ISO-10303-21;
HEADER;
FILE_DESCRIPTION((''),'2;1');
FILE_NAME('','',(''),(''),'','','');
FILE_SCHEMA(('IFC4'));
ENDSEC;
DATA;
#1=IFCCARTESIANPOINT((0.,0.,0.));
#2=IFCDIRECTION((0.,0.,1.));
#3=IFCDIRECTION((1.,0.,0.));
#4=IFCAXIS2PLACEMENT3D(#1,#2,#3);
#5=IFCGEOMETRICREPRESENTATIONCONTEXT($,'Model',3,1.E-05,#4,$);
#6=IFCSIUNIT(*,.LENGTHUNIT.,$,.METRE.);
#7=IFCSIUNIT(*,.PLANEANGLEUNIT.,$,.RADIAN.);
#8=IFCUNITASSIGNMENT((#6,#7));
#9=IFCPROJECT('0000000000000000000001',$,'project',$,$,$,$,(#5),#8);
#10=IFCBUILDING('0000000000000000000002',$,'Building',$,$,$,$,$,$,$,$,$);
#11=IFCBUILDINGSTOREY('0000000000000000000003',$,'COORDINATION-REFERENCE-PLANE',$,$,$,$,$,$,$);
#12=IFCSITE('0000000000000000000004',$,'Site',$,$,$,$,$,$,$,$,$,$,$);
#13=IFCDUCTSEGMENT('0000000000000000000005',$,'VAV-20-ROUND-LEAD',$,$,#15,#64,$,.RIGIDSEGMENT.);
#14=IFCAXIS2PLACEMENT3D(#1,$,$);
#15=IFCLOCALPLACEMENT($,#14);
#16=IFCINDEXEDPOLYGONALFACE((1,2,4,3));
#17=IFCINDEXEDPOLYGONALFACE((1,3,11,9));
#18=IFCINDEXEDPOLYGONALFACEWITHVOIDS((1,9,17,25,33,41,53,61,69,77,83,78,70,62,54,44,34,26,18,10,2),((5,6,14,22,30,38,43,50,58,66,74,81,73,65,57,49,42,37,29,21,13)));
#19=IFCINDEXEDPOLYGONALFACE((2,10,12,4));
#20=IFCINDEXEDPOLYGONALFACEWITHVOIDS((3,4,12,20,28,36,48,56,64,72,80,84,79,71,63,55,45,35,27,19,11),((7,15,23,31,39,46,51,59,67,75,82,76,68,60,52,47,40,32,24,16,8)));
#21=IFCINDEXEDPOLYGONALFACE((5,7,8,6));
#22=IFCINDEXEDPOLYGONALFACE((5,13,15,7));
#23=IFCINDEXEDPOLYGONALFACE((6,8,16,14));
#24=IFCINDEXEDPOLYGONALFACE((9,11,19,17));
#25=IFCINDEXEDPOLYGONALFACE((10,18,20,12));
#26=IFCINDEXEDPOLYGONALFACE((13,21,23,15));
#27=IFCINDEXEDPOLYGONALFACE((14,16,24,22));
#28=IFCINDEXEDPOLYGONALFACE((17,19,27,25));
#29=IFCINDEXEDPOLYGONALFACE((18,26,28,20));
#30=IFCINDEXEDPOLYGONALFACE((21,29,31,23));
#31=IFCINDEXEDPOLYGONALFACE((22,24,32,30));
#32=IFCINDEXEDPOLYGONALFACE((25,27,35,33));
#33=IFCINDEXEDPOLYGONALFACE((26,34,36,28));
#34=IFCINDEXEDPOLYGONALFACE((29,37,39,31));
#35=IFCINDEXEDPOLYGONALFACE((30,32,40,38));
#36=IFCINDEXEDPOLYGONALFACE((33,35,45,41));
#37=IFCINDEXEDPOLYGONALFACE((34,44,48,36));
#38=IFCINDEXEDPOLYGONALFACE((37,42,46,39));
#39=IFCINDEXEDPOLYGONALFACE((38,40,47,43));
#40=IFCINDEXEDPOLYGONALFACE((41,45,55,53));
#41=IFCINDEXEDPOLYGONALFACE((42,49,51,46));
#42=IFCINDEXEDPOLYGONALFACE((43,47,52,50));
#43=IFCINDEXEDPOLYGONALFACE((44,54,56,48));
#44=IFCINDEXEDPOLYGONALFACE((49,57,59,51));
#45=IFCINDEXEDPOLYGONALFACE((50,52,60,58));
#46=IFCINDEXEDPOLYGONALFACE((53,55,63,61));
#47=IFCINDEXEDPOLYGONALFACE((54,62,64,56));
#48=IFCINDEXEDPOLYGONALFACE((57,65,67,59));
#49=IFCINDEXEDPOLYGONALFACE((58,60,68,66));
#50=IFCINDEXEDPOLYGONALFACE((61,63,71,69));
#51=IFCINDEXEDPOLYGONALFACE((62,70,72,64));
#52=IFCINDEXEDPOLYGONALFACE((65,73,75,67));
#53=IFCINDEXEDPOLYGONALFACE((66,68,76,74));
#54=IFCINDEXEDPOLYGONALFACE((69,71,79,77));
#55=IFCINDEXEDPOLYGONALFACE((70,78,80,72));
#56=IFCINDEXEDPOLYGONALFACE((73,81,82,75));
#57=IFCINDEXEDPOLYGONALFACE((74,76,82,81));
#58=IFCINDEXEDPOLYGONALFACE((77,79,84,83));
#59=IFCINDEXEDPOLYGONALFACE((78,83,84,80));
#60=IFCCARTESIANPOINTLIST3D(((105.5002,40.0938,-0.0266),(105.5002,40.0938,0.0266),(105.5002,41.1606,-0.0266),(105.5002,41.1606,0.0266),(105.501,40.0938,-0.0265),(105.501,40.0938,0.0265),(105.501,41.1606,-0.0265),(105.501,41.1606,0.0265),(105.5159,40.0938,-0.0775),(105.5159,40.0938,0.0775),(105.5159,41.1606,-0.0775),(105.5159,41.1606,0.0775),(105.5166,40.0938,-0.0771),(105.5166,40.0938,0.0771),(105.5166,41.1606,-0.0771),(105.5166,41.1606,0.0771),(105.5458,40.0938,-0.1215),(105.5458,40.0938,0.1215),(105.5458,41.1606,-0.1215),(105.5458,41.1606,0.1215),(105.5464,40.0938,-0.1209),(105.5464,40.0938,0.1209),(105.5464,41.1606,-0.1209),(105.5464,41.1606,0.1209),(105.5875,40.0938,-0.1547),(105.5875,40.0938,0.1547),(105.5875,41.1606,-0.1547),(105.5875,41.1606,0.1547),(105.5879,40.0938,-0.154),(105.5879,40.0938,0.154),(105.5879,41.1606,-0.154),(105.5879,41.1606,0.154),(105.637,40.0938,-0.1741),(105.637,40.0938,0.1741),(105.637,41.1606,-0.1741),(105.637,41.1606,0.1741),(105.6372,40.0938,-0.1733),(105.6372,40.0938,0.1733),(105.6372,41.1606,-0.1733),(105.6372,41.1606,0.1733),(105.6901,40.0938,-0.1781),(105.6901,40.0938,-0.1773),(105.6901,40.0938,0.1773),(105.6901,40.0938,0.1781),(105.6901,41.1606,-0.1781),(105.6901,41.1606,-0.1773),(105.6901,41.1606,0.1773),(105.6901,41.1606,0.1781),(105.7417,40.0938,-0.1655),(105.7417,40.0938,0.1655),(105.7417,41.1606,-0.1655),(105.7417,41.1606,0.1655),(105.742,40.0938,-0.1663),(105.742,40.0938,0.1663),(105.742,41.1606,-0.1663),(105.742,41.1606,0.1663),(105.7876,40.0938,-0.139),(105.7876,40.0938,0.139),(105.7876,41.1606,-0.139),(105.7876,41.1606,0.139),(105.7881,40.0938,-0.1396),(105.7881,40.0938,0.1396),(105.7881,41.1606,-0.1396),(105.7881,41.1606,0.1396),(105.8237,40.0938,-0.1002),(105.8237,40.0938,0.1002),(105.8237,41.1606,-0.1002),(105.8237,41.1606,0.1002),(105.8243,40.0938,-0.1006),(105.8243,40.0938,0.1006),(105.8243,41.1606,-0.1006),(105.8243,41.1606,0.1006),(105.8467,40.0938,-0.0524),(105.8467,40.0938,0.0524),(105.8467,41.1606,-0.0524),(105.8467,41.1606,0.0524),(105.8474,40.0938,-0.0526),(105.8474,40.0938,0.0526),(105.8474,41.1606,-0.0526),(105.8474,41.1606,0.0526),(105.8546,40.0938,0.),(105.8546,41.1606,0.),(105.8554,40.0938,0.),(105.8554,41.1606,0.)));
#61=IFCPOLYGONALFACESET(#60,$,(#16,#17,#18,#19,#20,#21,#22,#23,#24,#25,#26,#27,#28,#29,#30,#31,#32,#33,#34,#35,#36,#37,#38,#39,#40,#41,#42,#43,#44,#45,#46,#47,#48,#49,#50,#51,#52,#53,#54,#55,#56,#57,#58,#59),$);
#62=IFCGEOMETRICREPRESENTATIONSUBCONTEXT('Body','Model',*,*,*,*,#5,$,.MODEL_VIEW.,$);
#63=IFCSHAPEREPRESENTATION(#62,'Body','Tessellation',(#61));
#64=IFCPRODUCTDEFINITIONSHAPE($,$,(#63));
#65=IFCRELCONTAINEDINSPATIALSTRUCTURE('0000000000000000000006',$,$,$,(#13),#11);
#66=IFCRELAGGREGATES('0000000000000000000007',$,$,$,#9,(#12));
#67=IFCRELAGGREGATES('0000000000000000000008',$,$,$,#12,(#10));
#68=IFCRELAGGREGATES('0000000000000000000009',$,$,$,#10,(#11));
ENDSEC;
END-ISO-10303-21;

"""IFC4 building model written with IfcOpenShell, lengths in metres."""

from ifc_helpers import new_model, si_unit, frame, origin, origin_with_axes, place, context, subcontext, project, spatial, hollow_circle, extrude, element, save


model = new_model("IFC4")

# Units and contexts
model_context = context("Model", 3, precision=1e-05, world=origin_with_axes())
body_context_1 = subcontext(model_context, "Body", "Model", "MODEL_VIEW")
ifc_project = project(units=[si_unit("LENGTHUNIT", "METRE"), si_unit("PLANEANGLEUNIT", "RADIAN")], contexts=[model_context])

# Site, building, storey
site = spatial("IfcSite", under=ifc_project, Name="Site")
building = spatial("IfcBuilding", under=site, Name="Building")
storey = spatial("IfcBuildingStorey", under=building, Name="COORDINATION-REFERENCE-PLANE")

# Duct segment
for number, where, z_axis, x_axis, name in (
    (1, (105.6768, 40.0938, 0.0), (0.0, 1.0, 0.0), (1.0, 0.0, 0.0), "VAV-20-ROUND-LEAD"),
):
    element("IfcDuctSegment", number, at=place(None, frame(where, z_axis=z_axis, x_axis=x_axis)), inside=storey, Name=name, PredefinedType="RIGIDSEGMENT", context=body_context_1, shape_type="SweptSolid", body=[
        extrude(hollow_circle(Radius=0.1786, WallThickness=0.0008), origin(), (0.0, 0.0, 1.0), 1.0668),
    ])

save(model, "model.ifc")
